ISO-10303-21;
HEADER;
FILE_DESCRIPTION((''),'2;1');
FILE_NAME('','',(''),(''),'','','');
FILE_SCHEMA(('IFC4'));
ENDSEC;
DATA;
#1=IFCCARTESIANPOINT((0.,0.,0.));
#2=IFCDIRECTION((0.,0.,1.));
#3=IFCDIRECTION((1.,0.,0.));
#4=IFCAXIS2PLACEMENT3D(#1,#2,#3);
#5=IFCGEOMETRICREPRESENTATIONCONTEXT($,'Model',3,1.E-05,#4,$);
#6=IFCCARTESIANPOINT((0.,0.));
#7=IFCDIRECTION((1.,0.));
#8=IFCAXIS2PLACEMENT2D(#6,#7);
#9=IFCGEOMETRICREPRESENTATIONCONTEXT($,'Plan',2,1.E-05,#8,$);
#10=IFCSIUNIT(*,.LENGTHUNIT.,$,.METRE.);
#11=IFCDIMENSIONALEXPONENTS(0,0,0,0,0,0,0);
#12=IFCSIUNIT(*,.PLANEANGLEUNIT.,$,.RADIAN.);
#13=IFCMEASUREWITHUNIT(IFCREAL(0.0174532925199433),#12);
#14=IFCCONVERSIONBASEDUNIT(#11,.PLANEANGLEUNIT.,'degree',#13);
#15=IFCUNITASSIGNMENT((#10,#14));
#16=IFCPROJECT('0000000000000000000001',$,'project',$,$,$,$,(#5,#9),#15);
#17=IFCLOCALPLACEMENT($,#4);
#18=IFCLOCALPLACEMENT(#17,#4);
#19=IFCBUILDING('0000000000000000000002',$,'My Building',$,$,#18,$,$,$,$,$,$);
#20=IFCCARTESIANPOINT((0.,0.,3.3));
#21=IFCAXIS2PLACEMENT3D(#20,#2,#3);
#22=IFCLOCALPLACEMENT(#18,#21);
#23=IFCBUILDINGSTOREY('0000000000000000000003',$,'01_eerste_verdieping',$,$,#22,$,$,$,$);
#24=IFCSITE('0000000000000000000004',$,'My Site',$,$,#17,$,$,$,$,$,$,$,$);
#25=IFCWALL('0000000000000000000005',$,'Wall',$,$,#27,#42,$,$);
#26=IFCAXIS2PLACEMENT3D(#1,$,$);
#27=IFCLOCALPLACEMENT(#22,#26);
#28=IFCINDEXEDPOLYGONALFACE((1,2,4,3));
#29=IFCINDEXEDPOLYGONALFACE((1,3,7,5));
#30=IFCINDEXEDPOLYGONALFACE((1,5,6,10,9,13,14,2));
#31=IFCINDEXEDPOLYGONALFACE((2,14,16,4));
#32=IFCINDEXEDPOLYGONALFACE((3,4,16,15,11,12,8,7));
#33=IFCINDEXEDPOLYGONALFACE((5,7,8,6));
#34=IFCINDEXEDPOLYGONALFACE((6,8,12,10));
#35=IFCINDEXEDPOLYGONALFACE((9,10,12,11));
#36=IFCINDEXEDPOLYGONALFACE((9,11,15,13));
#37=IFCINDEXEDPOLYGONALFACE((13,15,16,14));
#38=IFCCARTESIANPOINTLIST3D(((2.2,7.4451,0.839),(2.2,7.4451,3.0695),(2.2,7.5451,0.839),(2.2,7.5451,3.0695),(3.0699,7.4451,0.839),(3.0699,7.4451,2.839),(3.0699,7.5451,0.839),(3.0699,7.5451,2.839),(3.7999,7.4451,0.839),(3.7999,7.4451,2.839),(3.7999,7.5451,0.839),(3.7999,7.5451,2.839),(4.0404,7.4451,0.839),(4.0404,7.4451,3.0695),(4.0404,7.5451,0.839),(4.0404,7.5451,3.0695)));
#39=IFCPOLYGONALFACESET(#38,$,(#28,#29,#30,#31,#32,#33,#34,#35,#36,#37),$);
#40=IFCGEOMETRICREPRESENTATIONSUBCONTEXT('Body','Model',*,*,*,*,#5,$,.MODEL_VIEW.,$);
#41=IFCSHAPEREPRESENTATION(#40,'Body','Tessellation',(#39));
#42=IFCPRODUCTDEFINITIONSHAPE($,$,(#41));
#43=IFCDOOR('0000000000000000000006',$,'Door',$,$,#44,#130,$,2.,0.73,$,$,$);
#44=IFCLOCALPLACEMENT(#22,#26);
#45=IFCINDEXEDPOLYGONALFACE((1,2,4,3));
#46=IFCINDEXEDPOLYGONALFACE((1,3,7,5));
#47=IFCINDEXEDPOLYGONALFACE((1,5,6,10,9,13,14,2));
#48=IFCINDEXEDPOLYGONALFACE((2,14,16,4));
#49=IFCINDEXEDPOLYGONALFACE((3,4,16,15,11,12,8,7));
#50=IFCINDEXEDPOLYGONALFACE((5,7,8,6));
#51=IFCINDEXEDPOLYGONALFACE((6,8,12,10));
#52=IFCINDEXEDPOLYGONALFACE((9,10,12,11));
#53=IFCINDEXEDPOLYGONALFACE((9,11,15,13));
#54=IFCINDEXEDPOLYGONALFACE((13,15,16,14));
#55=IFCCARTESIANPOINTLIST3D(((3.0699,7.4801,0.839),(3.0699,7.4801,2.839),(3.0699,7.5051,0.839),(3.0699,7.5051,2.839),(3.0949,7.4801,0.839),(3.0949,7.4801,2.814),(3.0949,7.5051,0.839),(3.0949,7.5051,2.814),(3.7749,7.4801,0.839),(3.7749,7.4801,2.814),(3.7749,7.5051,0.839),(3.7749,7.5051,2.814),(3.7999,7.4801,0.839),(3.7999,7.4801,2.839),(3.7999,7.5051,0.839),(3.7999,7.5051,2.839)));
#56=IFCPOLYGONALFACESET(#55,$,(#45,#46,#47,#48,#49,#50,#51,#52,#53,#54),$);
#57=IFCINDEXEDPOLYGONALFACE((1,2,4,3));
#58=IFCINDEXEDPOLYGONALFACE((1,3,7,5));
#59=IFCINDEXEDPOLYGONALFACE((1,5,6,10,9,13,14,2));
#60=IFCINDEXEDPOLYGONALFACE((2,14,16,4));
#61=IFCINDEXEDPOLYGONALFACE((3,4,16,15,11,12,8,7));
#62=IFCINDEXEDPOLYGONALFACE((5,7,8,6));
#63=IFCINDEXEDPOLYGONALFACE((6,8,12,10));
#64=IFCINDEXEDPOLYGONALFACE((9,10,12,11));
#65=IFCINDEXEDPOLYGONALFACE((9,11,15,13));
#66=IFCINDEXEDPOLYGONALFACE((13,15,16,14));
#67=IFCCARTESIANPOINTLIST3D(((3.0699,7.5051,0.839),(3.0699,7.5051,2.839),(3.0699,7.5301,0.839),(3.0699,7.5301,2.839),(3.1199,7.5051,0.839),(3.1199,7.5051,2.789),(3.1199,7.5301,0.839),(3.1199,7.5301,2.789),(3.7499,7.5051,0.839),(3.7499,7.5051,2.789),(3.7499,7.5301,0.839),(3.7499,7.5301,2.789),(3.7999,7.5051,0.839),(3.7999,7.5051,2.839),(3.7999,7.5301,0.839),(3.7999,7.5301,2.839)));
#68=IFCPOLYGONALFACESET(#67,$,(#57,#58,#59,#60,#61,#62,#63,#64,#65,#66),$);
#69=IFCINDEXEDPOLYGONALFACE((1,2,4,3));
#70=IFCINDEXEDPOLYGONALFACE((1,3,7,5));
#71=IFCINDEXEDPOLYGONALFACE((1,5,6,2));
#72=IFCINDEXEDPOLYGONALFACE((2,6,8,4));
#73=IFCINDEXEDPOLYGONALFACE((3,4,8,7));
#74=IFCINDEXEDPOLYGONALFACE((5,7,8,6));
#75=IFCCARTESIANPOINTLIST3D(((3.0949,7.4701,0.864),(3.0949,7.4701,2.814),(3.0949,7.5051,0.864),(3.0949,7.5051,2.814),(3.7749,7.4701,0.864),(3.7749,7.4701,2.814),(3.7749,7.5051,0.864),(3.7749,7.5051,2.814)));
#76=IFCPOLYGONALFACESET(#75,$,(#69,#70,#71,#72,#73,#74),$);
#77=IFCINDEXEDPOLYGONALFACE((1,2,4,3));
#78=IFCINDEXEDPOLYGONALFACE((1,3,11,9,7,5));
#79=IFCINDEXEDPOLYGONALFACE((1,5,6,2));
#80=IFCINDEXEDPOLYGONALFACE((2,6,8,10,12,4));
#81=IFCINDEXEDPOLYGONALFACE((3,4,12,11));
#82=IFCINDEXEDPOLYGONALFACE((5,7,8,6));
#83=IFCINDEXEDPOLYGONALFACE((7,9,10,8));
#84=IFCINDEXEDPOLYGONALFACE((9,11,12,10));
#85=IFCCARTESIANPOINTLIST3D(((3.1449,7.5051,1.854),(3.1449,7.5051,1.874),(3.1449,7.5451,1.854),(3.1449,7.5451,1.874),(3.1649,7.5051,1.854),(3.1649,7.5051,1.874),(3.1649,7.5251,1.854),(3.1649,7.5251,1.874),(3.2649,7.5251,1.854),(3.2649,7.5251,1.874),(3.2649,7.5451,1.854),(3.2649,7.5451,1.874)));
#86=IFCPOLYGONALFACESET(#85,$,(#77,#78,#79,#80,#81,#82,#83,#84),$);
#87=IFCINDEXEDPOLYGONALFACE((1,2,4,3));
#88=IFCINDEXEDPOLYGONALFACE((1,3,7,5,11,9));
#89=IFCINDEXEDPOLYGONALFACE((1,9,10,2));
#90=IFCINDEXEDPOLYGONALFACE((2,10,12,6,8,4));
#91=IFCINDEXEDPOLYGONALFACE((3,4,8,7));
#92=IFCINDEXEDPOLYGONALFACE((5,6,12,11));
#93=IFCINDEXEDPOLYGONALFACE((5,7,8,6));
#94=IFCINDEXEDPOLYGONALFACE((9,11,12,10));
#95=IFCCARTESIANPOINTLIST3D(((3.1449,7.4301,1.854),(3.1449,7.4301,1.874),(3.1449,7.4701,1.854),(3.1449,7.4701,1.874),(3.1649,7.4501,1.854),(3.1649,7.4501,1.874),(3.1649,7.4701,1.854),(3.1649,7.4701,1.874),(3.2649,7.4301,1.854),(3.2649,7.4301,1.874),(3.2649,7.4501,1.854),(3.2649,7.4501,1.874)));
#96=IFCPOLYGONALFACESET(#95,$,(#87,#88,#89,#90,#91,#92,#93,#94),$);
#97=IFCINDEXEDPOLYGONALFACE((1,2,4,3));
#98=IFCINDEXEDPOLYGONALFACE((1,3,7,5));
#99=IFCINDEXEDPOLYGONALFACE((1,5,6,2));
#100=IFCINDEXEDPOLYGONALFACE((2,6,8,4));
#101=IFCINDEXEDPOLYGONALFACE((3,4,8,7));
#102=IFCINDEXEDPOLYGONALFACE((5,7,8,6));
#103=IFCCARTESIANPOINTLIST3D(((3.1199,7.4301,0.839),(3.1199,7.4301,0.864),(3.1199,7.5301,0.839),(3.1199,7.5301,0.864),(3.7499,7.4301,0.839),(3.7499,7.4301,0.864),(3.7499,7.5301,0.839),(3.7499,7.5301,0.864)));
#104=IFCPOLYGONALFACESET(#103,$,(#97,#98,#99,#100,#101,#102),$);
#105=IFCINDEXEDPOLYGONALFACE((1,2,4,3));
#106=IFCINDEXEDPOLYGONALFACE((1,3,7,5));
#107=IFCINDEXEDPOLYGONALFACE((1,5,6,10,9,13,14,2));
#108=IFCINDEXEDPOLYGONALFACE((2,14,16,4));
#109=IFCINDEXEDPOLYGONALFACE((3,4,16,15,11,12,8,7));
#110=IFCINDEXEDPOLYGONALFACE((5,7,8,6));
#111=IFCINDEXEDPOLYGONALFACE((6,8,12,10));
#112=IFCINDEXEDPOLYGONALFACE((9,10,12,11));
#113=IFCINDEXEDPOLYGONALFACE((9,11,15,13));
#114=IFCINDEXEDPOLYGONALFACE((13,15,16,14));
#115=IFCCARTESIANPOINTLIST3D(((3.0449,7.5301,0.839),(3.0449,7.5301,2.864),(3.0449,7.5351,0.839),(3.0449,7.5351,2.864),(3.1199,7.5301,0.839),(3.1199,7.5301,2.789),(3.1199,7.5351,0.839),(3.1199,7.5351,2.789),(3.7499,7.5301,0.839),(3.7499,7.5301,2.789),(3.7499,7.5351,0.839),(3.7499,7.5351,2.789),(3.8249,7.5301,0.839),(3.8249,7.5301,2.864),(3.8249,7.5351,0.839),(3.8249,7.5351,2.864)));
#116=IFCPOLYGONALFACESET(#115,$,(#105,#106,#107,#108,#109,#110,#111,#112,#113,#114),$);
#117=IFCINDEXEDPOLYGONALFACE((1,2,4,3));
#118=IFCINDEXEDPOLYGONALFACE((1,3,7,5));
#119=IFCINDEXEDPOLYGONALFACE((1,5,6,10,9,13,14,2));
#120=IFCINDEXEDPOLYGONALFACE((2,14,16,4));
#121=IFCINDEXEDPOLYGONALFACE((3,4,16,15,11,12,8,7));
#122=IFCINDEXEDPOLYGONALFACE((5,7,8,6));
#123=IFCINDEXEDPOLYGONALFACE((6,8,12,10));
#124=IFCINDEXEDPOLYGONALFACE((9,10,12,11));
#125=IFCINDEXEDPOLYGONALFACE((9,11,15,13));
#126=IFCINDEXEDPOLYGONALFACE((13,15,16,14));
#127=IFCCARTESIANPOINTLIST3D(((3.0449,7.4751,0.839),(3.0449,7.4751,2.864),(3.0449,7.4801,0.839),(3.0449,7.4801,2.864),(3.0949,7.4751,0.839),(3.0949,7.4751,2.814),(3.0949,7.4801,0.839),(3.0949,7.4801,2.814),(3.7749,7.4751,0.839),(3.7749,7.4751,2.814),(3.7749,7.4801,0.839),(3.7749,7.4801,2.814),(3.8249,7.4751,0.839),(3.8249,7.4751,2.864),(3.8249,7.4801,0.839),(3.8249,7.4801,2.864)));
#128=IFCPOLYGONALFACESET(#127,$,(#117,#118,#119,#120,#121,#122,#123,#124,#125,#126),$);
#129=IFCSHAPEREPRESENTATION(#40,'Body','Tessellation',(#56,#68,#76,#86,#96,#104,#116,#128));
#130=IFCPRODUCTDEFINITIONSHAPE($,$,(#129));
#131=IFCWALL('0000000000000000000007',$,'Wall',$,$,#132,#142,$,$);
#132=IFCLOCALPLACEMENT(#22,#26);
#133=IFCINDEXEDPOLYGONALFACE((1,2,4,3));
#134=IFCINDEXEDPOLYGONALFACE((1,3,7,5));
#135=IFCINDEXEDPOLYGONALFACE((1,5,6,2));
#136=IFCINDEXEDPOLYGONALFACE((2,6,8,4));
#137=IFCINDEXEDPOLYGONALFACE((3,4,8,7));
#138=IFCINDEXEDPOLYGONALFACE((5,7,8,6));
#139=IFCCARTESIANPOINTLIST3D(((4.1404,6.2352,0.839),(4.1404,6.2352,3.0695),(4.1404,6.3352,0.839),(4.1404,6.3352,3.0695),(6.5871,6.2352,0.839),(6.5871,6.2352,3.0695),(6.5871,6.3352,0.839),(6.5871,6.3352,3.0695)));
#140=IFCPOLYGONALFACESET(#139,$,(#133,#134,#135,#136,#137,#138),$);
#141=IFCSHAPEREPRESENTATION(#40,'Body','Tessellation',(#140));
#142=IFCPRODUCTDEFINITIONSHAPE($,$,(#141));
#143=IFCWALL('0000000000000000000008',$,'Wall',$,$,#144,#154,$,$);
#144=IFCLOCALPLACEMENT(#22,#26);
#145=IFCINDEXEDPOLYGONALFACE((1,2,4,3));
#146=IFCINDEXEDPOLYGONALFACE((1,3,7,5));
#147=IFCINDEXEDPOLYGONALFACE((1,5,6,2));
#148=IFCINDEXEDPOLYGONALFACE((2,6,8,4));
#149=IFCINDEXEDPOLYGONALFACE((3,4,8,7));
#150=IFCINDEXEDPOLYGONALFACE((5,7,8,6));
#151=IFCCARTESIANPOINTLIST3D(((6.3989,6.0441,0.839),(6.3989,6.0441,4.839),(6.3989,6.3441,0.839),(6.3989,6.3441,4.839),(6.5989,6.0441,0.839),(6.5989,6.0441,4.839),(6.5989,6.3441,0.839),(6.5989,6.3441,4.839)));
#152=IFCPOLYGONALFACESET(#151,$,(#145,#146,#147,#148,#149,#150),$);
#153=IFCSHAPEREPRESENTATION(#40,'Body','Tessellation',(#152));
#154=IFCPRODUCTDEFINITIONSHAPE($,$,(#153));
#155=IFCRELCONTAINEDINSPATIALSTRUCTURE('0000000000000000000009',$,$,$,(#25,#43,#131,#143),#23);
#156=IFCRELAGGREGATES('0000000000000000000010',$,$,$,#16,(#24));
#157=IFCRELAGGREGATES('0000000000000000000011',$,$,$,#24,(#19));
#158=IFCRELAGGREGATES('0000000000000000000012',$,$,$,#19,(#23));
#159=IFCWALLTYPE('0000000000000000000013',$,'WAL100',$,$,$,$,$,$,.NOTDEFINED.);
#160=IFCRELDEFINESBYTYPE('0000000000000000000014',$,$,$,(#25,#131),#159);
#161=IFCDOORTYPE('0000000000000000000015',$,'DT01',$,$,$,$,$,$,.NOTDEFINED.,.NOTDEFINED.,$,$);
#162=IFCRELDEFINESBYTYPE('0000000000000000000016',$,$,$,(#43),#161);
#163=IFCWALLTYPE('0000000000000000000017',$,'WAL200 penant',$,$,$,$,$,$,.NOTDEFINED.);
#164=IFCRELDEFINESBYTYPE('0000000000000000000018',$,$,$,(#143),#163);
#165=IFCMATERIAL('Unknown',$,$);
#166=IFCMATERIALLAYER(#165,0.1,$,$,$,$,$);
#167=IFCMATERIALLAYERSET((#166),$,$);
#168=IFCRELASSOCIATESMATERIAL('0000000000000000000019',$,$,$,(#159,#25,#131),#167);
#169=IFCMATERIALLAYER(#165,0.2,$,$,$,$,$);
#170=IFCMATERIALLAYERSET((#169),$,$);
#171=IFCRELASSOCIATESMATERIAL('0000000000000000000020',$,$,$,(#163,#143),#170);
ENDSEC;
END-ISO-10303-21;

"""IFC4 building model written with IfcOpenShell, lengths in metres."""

from ifc_helpers import new_model, entity, si_unit, converted_unit, frame, origin_with_axes, origin_2d_with_axis, place, context, subcontext, project, spatial, line, indexed_curve, outline, extrude, clip, halfspace, shape, source, transform, mapped, material, layer, layer_set, layer_usage, type_object, type_shapes, element, fill, save


model = new_model("IFC4")

# Units and contexts
model_context = context("Model", 3, precision=1e-05, world=origin_with_axes())
plan_context = context("Plan", 2, precision=1e-05, world=origin_2d_with_axis())
body_context_1 = subcontext(model_context, "Body", "Model", "MODEL_VIEW")
body_context_2 = subcontext(plan_context, "Body", "Plan", "PLAN_VIEW")
ifc_project = project(units=[si_unit("LENGTHUNIT", "METRE"), converted_unit("PLANEANGLEUNIT", "degree", entity("IfcReal", 0.0174532925199433), si_unit("PLANEANGLEUNIT", "RADIAN"), dimensions=[0, 0, 0, 0, 0, 0, 0])], contexts=[model_context, plan_context])

# Site, building, storey
site_placement = place(None, origin_with_axes())
site = spatial("IfcSite", under=ifc_project, at=site_placement, Name="My Site")
building_placement = place(site_placement, origin_with_axes())
building = spatial("IfcBuilding", under=site, at=building_placement, Name="My Building")
storey_placement = place(building_placement, frame((0.0, 0.0, 3.3), z_axis=(0.0, 0.0, 1.0), x_axis=(1.0, 0.0, 0.0)))
storey = spatial("IfcBuildingStorey", under=building, at=storey_placement, Name="01_eerste_verdieping")

# Shared definitions
ifc_material = material(Name="Unknown")

# Shared definitions
ifc_layer_1 = layer(ifc_material, 0.1)
ifc_layer_set_1 = layer_set([ifc_layer_1])
wall_type_1 = type_object("IfcWallType", Name="WAL100", PredefinedType="NOTDEFINED", material=ifc_layer_set_1)

# Wall, opening, door
ifc_layer_usage_1 = layer_usage(ifc_layer_set_1, "AXIS2", "POSITIVE", 0.0)
wall_1_placement = place(storey_placement, frame((2.2, 7.4451, 0.839), z_axis=(0.0, 0.0, 1.0), x_axis=(1.0, -0.000001, 0.0)))
wall_1 = element("IfcWall", 1, at=wall_1_placement, inside=storey, type_object=wall_type_1, material=ifc_layer_usage_1, Name="Wall", context=body_context_1, shape_type="Clipping", body=[
    clip(extrude(outline(indexed_curve([(0.0, 0.0), (0.0, 0.1), (1.8404, 0.1), (1.8404, 0.0), (0.0, 0.0)], self_intersect=False)), origin_with_axes(), (0.0, 0.0, 1.0), 6.3695), halfspace(frame((0.0, 0.0, 2.2305), z_axis=(0.0, 0.0, 1.0), x_axis=(-1.0, 0.0, 0.0)), False)),
])
shared_shape_1 = source(origin_with_axes(), body_context_1, "Body", "SweptSolid", [
    extrude(outline(indexed_curve([(0.0, 0.0), (0.73, 0.0), (0.73, 2.0), (0.0, 2.0)], segments=[line(1, 2, 3, 4, 1)])), frame((0.0, -0.1, 0.0), z_axis=(0.0, -1.0, 0.0), x_axis=(1.0, 0.0, 0.0)), (0.0, 0.0, -1.0), 0.3),
])
opening_placement = place(wall_1_placement, frame((0.8699, 0.0, 0.0), z_axis=(0.0, 0.0, 1.0), x_axis=(1.0, 0.000001, 0.0)))
opening = element("IfcOpeningElement", 2, at=opening_placement, cuts=wall_1, PredefinedType="OPENING", context=body_context_1, shape_type="MappedRepresentation", body=[
    mapped(shared_shape_1, transform((0.0, 0.0, 0.0), x_axis=(1.0, 0.0, 0.0), y_axis=(0.0, 1.0, 0.0), z_axis=(0.0, 0.0, 1.0), scale=1.0)),
])
door_type = type_object("IfcDoorType", Name="DT01", OperationType="NOTDEFINED", PredefinedType="NOTDEFINED")
shared_shape_2 = source(origin_with_axes(), body_context_1, "Body", "SweptSolid", [
    extrude(outline(indexed_curve([(0.0, 0.0), (0.0, 2.0), (0.73, 2.0), (0.73, 0.0), (0.705, 0.0), (0.705, 1.975), (0.025, 1.975), (0.025, 0.0)], segments=[line(1, 2, 3, 4, 5, 6, 7, 8, 1)])), frame((0.0, 0.025, 0.0), z_axis=(0.0, -1.0, 0.0), x_axis=(1.0, 0.0, 0.0)), (0.0, 0.0, -1.0), 0.025),
    extrude(outline(indexed_curve([(0.0, 0.0), (0.0, 2.0), (0.73, 2.0), (0.73, 0.0), (0.68, 0.0), (0.68, 1.95), (0.05, 1.95), (0.05, 0.0)], segments=[line(1, 2, 3, 4, 5, 6, 7, 8, 1)])), frame((0.0, 0.0, 0.0), z_axis=(0.0, -1.0, 0.0), x_axis=(1.0, 0.0, 0.0)), (0.0, 0.0, -1.0), 0.025),
    extrude(outline(indexed_curve([(0.0, 0.0), (0.68, 0.0), (0.68, 0.035), (0.0, 0.035)], segments=[line(1, 2, 3, 4, 1)])), frame((0.025, 0.025, 0.025), z_axis=(0.0, 0.0, 1.0), x_axis=(1.0, 0.0, 0.0)), (0.0, 0.0, 1.0), 1.95),
    extrude(outline(indexed_curve([(0.0, 0.0), (0.0, -0.04), (-0.12, -0.04), (-0.12, -0.02), (-0.02, -0.02), (-0.02, 0.0)], segments=[line(1, 2, 3, 4, 5, 6, 1)])), frame((0.655, 0.025, 1.015), z_axis=(0.0, 0.0, 1.0), x_axis=(1.0, 0.0, 0.0)), (0.0, 0.0, 1.0), 0.02),
    extrude(outline(indexed_curve([(0.0, 0.0), (0.0, 0.04), (-0.12, 0.04), (-0.12, 0.02), (-0.02, 0.02), (-0.02, 0.0)], segments=[line(1, 2, 3, 4, 5, 6, 1)])), frame((0.655, 0.06, 1.015), z_axis=(0.0, 0.0, 1.0), x_axis=(1.0, 0.0, 0.0)), (0.0, 0.0, 1.0), 0.02),
    extrude(outline(indexed_curve([(0.0, 0.0), (0.63, 0.0), (0.63, 0.1), (0.0, 0.1)], segments=[line(1, 2, 3, 4, 1)])), frame((0.05, 0.0, 0.0), z_axis=(0.0, 0.0, 1.0), x_axis=(1.0, 0.0, 0.0)), (0.0, 0.0, 1.0), 0.025),
    extrude(outline(indexed_curve([(0.0, 0.0), (0.0, 2.025), (0.78, 2.025), (0.78, 0.0), (0.705, 0.0), (0.705, 1.95), (0.075, 1.95), (0.075, 0.0)], segments=[line(1, 2, 3, 4, 5, 6, 7, 8, 1)])), frame((-0.025, -0.005, 0.0), z_axis=(0.0, -1.0, 0.0), x_axis=(1.0, 0.0, 0.0)), (0.0, 0.0, -1.0), 0.005),
    extrude(outline(indexed_curve([(0.0, 0.0), (0.0, 2.025), (0.78, 2.025), (0.78, 0.0), (0.73, 0.0), (0.73, 1.975), (0.05, 1.975), (0.05, 0.0)], segments=[line(1, 2, 3, 4, 5, 6, 7, 8, 1)])), frame((-0.025, 0.05, 0.0), z_axis=(0.0, -1.0, 0.0), x_axis=(1.0, 0.0, 0.0)), (0.0, 0.0, -1.0), 0.005),
])
shared_shape_3 = source(origin_with_axes(), body_context_2, "Body", "Curve2D", [
    entity("IfcIndexedPolyCurve", entity("IfcCartesianPointList2D", [[0.0, 0.0], [0.0, 0.05], [0.025, 0.05], [0.025, 0.025], [0.05, 0.025], [0.05, 0.0]]), [entity("IfcLineIndex", [1, 2, 3, 4, 5, 6, 1])]),
    entity("IfcIndexedPolyCurve", entity("IfcCartesianPointList2D", [[0.73, 0.0], [0.73, 0.05], [0.705, 0.05], [0.705, 0.025], [0.68, 0.025], [0.68, 0.0]]), [entity("IfcLineIndex", [1, 2, 3, 4, 5, 6, 1])]),
    entity("IfcTrimmedCurve", entity("IfcEllipse", entity("IfcAxis2Placement2D", entity("IfcCartesianPoint", [0.06, 0.05]), entity("IfcDirection", [1.0, 0.0])), 0.645, 0.68), [entity("IfcCartesianPoint", [0.705, 0.05])], [entity("IfcCartesianPoint", [0.06, 0.73])], True, "CARTESIAN"),
    entity("IfcIndexedPolyCurve", entity("IfcCartesianPointList2D", [[0.025, 0.05], [0.06, 0.05], [0.06, 0.73], [0.025, 0.73]]), [entity("IfcLineIndex", [1, 2, 3, 4, 1])]),
])
type_shapes(door_type, [shared_shape_2, shared_shape_3])
door_placement = place(opening_placement, frame((0.73, 0.085, 0.0), z_axis=(0.0, 0.0, 1.0), x_axis=(-1.0, 0.0, 0.0)))
door = element("IfcDoor", 3, at=door_placement, inside=storey, type_object=door_type, Name="Door", OverallHeight=2.0, OverallWidth=0.73, shapes=[
    shape(body_context_1, "Body", "MappedRepresentation", [mapped(shared_shape_2, transform((0.0, 0.0, 0.0), x_axis=(1.0, 0.0, 0.0), y_axis=(0.0, 1.0, 0.0), z_axis=(0.0, 0.0, 1.0), scale=1.0))]),
    shape(body_context_2, "Body", "MappedRepresentation", [mapped(shared_shape_3, transform((0.0, 0.0, 0.0), x_axis=(1.0, 0.0, 0.0), y_axis=(0.0, 1.0, 0.0), z_axis=(0.0, 0.0, 1.0), scale=1.0))]),
])
fill(opening, door)

# Walls
ifc_layer_usage_2 = layer_usage(ifc_layer_set_1, "AXIS2", "POSITIVE", 0.0)
wall_2_placement = place(storey_placement, frame((4.1404, 6.2352, 0.839), z_axis=(0.0, 0.0, 1.0), x_axis=(1.0, 0.0, 0.0)))
element("IfcWall", 4, at=wall_2_placement, inside=storey, type_object=wall_type_1, material=ifc_layer_usage_2, Name="Wall", context=body_context_1, shape_type="Clipping", body=[
    clip(extrude(outline(indexed_curve([(0.0, 0.0), (0.0, 0.1), (2.4466, 0.1), (2.4466, 0.0), (0.0, 0.0)], self_intersect=False)), origin_with_axes(), (0.0, 0.0, 1.0), 6.3695), halfspace(frame((0.0, 0.0, 2.2305), z_axis=(0.0, 0.0, 1.0), x_axis=(-1.0, 0.0, 0.0)), False)),
])
ifc_layer_2 = layer(ifc_material, 0.2)
ifc_layer_set_2 = layer_set([ifc_layer_2])
ifc_layer_usage_3 = layer_usage(ifc_layer_set_2, "AXIS2", "POSITIVE", 0.0)
wall_type_2 = type_object("IfcWallType", Name="WAL200 penant", PredefinedType="NOTDEFINED", material=ifc_layer_set_2)
wall_3_placement = place(storey_placement, frame((6.5989, 6.0441, 0.839), z_axis=(0.0, 0.0, 1.0), x_axis=(0.0, 1.0, 0.0)))
element("IfcWall", 5, at=wall_3_placement, inside=storey, type_object=wall_type_2, material=ifc_layer_usage_3, Name="Wall", context=body_context_1, shape_type="SweptSolid", body=[
    extrude(outline(indexed_curve([(0.0, 0.0), (0.0, 0.2), (0.3, 0.2), (0.3, 0.0), (0.0, 0.0)], self_intersect=False)), origin_with_axes(), (0.0, 0.0, 1.0), 4.0),
])

save(model, "model.ifc")
